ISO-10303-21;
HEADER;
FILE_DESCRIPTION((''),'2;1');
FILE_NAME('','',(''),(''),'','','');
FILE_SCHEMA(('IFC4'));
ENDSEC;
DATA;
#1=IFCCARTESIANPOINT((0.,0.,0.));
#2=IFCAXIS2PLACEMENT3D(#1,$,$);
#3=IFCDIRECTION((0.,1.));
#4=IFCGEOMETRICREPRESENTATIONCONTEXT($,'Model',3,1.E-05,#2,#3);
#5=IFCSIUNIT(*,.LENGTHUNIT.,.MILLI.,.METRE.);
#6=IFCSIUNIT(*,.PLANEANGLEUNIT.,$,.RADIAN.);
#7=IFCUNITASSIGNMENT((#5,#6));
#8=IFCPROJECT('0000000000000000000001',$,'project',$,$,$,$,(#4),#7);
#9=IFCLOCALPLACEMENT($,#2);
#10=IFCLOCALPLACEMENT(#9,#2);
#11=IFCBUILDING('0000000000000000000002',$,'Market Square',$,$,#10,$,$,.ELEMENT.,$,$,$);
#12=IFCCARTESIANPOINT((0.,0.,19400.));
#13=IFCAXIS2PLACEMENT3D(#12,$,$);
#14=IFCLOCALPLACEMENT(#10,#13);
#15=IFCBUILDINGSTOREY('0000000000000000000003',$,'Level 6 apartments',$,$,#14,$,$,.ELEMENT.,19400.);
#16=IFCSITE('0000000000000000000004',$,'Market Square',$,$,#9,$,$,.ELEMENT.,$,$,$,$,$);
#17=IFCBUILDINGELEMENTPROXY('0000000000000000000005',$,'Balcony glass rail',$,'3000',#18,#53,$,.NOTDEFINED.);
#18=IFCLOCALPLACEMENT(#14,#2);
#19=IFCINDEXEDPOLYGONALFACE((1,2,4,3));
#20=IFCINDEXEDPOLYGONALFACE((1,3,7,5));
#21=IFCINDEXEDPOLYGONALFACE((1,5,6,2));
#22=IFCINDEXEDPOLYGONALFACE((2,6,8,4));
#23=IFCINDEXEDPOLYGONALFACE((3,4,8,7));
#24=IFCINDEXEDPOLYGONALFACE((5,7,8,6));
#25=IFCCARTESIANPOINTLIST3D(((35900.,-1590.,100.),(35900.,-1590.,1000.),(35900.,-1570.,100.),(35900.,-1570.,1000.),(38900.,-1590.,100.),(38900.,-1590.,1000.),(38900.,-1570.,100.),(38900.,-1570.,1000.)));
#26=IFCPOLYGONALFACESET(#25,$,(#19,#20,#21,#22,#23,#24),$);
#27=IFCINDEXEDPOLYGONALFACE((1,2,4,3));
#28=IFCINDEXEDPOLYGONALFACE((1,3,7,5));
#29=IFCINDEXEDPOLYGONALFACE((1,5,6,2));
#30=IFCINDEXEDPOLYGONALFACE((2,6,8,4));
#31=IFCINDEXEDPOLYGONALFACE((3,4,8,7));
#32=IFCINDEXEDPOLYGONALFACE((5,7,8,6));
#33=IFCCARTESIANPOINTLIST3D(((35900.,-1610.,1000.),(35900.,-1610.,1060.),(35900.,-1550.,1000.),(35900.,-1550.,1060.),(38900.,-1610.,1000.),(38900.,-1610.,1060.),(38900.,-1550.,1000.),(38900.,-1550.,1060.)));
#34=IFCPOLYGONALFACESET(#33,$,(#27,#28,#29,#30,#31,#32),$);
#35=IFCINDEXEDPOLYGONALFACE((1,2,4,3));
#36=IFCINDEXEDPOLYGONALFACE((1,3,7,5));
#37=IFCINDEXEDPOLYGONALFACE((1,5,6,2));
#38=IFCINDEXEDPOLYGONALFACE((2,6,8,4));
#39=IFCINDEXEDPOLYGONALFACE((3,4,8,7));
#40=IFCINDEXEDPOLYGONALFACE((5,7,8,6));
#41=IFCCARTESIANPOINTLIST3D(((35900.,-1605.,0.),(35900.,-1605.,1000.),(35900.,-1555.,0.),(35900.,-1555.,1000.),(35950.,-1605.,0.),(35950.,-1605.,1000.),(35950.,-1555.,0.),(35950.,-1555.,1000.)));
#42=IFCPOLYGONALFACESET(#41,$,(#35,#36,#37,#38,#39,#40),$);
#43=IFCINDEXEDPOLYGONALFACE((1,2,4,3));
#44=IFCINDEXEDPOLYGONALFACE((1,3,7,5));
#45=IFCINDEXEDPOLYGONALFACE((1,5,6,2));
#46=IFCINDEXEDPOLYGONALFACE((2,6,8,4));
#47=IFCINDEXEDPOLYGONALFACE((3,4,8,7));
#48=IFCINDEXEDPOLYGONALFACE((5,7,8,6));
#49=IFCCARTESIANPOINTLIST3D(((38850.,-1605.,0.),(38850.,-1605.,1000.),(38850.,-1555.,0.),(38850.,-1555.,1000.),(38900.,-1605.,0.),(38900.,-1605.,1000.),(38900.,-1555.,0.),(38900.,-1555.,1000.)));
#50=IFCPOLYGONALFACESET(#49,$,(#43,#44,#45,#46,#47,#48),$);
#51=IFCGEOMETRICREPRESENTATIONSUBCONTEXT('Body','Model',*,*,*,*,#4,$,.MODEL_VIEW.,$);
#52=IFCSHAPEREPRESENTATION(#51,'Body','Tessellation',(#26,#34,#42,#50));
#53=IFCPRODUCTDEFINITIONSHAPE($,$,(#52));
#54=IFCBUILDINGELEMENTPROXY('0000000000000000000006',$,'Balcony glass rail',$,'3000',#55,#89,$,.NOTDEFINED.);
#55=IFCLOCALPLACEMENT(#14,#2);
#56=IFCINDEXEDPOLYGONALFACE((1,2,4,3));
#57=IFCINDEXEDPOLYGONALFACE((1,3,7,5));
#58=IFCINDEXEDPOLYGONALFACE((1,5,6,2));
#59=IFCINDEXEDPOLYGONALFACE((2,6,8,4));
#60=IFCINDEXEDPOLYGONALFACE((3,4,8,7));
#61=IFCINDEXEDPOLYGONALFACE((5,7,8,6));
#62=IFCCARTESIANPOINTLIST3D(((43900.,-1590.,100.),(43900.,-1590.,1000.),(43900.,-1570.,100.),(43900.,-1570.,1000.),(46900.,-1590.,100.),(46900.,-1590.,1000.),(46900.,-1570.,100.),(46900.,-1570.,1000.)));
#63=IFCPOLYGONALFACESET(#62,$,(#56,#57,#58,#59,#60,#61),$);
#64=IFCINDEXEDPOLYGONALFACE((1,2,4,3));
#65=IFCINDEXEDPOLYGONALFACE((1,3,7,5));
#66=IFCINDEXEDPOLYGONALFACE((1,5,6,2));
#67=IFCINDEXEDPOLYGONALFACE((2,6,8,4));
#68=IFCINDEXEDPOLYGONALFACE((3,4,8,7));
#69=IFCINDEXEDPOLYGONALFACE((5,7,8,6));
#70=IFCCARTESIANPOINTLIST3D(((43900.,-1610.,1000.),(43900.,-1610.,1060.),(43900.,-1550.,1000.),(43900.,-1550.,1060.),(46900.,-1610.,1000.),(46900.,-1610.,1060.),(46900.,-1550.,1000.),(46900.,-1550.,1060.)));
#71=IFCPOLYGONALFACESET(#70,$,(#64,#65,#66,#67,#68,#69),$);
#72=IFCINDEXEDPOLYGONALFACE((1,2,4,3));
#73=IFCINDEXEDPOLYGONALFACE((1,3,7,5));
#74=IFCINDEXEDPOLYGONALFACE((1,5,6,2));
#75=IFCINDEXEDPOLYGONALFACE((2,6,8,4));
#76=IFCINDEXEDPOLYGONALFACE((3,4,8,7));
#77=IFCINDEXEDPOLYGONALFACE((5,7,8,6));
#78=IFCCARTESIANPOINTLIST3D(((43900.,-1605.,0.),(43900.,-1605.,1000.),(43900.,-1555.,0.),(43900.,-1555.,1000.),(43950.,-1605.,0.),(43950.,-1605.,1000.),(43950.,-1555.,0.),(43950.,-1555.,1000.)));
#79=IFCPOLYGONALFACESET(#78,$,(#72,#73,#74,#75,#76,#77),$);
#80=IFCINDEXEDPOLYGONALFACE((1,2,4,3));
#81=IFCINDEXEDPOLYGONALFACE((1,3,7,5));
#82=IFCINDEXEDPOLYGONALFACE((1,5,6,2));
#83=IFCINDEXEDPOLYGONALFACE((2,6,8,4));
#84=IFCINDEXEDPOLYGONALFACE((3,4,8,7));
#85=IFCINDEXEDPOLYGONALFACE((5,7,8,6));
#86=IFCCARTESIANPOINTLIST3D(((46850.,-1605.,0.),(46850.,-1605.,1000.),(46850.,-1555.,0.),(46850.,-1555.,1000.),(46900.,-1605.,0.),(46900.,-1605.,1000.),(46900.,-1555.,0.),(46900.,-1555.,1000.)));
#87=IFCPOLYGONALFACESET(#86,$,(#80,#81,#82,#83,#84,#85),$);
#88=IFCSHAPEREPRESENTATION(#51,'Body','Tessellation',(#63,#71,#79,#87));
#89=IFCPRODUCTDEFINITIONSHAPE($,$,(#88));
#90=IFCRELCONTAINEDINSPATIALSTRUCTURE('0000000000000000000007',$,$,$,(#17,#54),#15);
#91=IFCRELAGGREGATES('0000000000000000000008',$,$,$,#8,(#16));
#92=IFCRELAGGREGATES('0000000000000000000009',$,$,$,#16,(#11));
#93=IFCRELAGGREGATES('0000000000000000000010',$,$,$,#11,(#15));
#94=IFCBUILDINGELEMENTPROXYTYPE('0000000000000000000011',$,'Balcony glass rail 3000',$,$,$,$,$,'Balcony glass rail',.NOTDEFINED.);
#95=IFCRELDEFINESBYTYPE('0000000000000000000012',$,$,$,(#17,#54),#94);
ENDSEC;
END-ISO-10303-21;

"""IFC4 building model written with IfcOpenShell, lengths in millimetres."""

from ifc_helpers import new_model, si_unit, direction, frame, origin, place, context, subcontext, project, spatial, polyline, outline, extrude, source, transform, mapped, type_object, type_shapes, element, save


model = new_model("IFC4")

# Units and contexts
model_context = context("Model", 3, precision=1e-05, world=origin(), true_north=direction((0.0, 1.0)))
body_context = subcontext(model_context, "Body", "Model", "MODEL_VIEW")
ifc_project = project(units=[si_unit("LENGTHUNIT", "METRE", prefix="MILLI"), si_unit("PLANEANGLEUNIT", "RADIAN")], contexts=[model_context])

# Site, building, storey
site_placement = place(None, origin())
site = spatial("IfcSite", under=ifc_project, at=site_placement, Name="Market Square", CompositionType="ELEMENT")
building_placement = place(site_placement, origin())
building = spatial("IfcBuilding", under=site, at=building_placement, Name="Market Square", CompositionType="ELEMENT")
storey_placement = place(building_placement, frame((0.0, 0.0, 19400.0)))
storey = spatial("IfcBuildingStorey", under=building, at=storey_placement, Name="Level 6 apartments", CompositionType="ELEMENT", Elevation=19400.0)

# Building element proxies
building_element_proxy_type = type_object("IfcBuildingElementProxyType", Name="Balcony glass rail 3000", ElementType="Balcony glass rail", PredefinedType="NOTDEFINED")
shared_shape = source(origin(), body_context, "Body", "SweptSolid", [
    extrude(outline(polyline([(0.0, -10.0), (3000.0, -10.0), (3000.0, 10.0), (0.0, 10.0), (0.0, -10.0)])), frame((0.0, 0.0, 100.0)), (0.0, 0.0, 1.0), 900.0),
    extrude(outline(polyline([(0.0, -30.0), (3000.0, -30.0), (3000.0, 30.0), (0.0, 30.0), (0.0, -30.0)])), frame((0.0, 0.0, 1000.0)), (0.0, 0.0, 1.0), 60.0),
    extrude(outline(polyline([(0.0, -25.0), (50.0, -25.0), (50.0, 25.0), (0.0, 25.0), (0.0, -25.0)])), origin(), (0.0, 0.0, 1.0), 1000.0),
    extrude(outline(polyline([(2950.0, -25.0), (3000.0, -25.0), (3000.0, 25.0), (2950.0, 25.0), (2950.0, -25.0)])), origin(), (0.0, 0.0, 1.0), 1000.0),
])
type_shapes(building_element_proxy_type, [shared_shape])
for number, where, z_axis, x_axis, name in (
    (1, (35900.0, -1580.0, 0.0), (0.0, 0.0, 1.0), (1.0, 0.0, 0.0), "Balcony glass rail"),
    (2, (43900.0, -1580.0, 0.0), (0.0, 0.0, 1.0), (1.0, 0.0, 0.0), "Balcony glass rail"),
):
    element("IfcBuildingElementProxy", number, at=place(storey_placement, frame(where, z_axis=z_axis, x_axis=x_axis)), inside=storey, type_object=building_element_proxy_type, Name=name, ObjectType="3000", PredefinedType="NOTDEFINED", context=body_context, shape_type="MappedRepresentation", body=[
        mapped(shared_shape, transform((0.0, 0.0, 0.0))),
    ])

save(model, "model.ifc")
